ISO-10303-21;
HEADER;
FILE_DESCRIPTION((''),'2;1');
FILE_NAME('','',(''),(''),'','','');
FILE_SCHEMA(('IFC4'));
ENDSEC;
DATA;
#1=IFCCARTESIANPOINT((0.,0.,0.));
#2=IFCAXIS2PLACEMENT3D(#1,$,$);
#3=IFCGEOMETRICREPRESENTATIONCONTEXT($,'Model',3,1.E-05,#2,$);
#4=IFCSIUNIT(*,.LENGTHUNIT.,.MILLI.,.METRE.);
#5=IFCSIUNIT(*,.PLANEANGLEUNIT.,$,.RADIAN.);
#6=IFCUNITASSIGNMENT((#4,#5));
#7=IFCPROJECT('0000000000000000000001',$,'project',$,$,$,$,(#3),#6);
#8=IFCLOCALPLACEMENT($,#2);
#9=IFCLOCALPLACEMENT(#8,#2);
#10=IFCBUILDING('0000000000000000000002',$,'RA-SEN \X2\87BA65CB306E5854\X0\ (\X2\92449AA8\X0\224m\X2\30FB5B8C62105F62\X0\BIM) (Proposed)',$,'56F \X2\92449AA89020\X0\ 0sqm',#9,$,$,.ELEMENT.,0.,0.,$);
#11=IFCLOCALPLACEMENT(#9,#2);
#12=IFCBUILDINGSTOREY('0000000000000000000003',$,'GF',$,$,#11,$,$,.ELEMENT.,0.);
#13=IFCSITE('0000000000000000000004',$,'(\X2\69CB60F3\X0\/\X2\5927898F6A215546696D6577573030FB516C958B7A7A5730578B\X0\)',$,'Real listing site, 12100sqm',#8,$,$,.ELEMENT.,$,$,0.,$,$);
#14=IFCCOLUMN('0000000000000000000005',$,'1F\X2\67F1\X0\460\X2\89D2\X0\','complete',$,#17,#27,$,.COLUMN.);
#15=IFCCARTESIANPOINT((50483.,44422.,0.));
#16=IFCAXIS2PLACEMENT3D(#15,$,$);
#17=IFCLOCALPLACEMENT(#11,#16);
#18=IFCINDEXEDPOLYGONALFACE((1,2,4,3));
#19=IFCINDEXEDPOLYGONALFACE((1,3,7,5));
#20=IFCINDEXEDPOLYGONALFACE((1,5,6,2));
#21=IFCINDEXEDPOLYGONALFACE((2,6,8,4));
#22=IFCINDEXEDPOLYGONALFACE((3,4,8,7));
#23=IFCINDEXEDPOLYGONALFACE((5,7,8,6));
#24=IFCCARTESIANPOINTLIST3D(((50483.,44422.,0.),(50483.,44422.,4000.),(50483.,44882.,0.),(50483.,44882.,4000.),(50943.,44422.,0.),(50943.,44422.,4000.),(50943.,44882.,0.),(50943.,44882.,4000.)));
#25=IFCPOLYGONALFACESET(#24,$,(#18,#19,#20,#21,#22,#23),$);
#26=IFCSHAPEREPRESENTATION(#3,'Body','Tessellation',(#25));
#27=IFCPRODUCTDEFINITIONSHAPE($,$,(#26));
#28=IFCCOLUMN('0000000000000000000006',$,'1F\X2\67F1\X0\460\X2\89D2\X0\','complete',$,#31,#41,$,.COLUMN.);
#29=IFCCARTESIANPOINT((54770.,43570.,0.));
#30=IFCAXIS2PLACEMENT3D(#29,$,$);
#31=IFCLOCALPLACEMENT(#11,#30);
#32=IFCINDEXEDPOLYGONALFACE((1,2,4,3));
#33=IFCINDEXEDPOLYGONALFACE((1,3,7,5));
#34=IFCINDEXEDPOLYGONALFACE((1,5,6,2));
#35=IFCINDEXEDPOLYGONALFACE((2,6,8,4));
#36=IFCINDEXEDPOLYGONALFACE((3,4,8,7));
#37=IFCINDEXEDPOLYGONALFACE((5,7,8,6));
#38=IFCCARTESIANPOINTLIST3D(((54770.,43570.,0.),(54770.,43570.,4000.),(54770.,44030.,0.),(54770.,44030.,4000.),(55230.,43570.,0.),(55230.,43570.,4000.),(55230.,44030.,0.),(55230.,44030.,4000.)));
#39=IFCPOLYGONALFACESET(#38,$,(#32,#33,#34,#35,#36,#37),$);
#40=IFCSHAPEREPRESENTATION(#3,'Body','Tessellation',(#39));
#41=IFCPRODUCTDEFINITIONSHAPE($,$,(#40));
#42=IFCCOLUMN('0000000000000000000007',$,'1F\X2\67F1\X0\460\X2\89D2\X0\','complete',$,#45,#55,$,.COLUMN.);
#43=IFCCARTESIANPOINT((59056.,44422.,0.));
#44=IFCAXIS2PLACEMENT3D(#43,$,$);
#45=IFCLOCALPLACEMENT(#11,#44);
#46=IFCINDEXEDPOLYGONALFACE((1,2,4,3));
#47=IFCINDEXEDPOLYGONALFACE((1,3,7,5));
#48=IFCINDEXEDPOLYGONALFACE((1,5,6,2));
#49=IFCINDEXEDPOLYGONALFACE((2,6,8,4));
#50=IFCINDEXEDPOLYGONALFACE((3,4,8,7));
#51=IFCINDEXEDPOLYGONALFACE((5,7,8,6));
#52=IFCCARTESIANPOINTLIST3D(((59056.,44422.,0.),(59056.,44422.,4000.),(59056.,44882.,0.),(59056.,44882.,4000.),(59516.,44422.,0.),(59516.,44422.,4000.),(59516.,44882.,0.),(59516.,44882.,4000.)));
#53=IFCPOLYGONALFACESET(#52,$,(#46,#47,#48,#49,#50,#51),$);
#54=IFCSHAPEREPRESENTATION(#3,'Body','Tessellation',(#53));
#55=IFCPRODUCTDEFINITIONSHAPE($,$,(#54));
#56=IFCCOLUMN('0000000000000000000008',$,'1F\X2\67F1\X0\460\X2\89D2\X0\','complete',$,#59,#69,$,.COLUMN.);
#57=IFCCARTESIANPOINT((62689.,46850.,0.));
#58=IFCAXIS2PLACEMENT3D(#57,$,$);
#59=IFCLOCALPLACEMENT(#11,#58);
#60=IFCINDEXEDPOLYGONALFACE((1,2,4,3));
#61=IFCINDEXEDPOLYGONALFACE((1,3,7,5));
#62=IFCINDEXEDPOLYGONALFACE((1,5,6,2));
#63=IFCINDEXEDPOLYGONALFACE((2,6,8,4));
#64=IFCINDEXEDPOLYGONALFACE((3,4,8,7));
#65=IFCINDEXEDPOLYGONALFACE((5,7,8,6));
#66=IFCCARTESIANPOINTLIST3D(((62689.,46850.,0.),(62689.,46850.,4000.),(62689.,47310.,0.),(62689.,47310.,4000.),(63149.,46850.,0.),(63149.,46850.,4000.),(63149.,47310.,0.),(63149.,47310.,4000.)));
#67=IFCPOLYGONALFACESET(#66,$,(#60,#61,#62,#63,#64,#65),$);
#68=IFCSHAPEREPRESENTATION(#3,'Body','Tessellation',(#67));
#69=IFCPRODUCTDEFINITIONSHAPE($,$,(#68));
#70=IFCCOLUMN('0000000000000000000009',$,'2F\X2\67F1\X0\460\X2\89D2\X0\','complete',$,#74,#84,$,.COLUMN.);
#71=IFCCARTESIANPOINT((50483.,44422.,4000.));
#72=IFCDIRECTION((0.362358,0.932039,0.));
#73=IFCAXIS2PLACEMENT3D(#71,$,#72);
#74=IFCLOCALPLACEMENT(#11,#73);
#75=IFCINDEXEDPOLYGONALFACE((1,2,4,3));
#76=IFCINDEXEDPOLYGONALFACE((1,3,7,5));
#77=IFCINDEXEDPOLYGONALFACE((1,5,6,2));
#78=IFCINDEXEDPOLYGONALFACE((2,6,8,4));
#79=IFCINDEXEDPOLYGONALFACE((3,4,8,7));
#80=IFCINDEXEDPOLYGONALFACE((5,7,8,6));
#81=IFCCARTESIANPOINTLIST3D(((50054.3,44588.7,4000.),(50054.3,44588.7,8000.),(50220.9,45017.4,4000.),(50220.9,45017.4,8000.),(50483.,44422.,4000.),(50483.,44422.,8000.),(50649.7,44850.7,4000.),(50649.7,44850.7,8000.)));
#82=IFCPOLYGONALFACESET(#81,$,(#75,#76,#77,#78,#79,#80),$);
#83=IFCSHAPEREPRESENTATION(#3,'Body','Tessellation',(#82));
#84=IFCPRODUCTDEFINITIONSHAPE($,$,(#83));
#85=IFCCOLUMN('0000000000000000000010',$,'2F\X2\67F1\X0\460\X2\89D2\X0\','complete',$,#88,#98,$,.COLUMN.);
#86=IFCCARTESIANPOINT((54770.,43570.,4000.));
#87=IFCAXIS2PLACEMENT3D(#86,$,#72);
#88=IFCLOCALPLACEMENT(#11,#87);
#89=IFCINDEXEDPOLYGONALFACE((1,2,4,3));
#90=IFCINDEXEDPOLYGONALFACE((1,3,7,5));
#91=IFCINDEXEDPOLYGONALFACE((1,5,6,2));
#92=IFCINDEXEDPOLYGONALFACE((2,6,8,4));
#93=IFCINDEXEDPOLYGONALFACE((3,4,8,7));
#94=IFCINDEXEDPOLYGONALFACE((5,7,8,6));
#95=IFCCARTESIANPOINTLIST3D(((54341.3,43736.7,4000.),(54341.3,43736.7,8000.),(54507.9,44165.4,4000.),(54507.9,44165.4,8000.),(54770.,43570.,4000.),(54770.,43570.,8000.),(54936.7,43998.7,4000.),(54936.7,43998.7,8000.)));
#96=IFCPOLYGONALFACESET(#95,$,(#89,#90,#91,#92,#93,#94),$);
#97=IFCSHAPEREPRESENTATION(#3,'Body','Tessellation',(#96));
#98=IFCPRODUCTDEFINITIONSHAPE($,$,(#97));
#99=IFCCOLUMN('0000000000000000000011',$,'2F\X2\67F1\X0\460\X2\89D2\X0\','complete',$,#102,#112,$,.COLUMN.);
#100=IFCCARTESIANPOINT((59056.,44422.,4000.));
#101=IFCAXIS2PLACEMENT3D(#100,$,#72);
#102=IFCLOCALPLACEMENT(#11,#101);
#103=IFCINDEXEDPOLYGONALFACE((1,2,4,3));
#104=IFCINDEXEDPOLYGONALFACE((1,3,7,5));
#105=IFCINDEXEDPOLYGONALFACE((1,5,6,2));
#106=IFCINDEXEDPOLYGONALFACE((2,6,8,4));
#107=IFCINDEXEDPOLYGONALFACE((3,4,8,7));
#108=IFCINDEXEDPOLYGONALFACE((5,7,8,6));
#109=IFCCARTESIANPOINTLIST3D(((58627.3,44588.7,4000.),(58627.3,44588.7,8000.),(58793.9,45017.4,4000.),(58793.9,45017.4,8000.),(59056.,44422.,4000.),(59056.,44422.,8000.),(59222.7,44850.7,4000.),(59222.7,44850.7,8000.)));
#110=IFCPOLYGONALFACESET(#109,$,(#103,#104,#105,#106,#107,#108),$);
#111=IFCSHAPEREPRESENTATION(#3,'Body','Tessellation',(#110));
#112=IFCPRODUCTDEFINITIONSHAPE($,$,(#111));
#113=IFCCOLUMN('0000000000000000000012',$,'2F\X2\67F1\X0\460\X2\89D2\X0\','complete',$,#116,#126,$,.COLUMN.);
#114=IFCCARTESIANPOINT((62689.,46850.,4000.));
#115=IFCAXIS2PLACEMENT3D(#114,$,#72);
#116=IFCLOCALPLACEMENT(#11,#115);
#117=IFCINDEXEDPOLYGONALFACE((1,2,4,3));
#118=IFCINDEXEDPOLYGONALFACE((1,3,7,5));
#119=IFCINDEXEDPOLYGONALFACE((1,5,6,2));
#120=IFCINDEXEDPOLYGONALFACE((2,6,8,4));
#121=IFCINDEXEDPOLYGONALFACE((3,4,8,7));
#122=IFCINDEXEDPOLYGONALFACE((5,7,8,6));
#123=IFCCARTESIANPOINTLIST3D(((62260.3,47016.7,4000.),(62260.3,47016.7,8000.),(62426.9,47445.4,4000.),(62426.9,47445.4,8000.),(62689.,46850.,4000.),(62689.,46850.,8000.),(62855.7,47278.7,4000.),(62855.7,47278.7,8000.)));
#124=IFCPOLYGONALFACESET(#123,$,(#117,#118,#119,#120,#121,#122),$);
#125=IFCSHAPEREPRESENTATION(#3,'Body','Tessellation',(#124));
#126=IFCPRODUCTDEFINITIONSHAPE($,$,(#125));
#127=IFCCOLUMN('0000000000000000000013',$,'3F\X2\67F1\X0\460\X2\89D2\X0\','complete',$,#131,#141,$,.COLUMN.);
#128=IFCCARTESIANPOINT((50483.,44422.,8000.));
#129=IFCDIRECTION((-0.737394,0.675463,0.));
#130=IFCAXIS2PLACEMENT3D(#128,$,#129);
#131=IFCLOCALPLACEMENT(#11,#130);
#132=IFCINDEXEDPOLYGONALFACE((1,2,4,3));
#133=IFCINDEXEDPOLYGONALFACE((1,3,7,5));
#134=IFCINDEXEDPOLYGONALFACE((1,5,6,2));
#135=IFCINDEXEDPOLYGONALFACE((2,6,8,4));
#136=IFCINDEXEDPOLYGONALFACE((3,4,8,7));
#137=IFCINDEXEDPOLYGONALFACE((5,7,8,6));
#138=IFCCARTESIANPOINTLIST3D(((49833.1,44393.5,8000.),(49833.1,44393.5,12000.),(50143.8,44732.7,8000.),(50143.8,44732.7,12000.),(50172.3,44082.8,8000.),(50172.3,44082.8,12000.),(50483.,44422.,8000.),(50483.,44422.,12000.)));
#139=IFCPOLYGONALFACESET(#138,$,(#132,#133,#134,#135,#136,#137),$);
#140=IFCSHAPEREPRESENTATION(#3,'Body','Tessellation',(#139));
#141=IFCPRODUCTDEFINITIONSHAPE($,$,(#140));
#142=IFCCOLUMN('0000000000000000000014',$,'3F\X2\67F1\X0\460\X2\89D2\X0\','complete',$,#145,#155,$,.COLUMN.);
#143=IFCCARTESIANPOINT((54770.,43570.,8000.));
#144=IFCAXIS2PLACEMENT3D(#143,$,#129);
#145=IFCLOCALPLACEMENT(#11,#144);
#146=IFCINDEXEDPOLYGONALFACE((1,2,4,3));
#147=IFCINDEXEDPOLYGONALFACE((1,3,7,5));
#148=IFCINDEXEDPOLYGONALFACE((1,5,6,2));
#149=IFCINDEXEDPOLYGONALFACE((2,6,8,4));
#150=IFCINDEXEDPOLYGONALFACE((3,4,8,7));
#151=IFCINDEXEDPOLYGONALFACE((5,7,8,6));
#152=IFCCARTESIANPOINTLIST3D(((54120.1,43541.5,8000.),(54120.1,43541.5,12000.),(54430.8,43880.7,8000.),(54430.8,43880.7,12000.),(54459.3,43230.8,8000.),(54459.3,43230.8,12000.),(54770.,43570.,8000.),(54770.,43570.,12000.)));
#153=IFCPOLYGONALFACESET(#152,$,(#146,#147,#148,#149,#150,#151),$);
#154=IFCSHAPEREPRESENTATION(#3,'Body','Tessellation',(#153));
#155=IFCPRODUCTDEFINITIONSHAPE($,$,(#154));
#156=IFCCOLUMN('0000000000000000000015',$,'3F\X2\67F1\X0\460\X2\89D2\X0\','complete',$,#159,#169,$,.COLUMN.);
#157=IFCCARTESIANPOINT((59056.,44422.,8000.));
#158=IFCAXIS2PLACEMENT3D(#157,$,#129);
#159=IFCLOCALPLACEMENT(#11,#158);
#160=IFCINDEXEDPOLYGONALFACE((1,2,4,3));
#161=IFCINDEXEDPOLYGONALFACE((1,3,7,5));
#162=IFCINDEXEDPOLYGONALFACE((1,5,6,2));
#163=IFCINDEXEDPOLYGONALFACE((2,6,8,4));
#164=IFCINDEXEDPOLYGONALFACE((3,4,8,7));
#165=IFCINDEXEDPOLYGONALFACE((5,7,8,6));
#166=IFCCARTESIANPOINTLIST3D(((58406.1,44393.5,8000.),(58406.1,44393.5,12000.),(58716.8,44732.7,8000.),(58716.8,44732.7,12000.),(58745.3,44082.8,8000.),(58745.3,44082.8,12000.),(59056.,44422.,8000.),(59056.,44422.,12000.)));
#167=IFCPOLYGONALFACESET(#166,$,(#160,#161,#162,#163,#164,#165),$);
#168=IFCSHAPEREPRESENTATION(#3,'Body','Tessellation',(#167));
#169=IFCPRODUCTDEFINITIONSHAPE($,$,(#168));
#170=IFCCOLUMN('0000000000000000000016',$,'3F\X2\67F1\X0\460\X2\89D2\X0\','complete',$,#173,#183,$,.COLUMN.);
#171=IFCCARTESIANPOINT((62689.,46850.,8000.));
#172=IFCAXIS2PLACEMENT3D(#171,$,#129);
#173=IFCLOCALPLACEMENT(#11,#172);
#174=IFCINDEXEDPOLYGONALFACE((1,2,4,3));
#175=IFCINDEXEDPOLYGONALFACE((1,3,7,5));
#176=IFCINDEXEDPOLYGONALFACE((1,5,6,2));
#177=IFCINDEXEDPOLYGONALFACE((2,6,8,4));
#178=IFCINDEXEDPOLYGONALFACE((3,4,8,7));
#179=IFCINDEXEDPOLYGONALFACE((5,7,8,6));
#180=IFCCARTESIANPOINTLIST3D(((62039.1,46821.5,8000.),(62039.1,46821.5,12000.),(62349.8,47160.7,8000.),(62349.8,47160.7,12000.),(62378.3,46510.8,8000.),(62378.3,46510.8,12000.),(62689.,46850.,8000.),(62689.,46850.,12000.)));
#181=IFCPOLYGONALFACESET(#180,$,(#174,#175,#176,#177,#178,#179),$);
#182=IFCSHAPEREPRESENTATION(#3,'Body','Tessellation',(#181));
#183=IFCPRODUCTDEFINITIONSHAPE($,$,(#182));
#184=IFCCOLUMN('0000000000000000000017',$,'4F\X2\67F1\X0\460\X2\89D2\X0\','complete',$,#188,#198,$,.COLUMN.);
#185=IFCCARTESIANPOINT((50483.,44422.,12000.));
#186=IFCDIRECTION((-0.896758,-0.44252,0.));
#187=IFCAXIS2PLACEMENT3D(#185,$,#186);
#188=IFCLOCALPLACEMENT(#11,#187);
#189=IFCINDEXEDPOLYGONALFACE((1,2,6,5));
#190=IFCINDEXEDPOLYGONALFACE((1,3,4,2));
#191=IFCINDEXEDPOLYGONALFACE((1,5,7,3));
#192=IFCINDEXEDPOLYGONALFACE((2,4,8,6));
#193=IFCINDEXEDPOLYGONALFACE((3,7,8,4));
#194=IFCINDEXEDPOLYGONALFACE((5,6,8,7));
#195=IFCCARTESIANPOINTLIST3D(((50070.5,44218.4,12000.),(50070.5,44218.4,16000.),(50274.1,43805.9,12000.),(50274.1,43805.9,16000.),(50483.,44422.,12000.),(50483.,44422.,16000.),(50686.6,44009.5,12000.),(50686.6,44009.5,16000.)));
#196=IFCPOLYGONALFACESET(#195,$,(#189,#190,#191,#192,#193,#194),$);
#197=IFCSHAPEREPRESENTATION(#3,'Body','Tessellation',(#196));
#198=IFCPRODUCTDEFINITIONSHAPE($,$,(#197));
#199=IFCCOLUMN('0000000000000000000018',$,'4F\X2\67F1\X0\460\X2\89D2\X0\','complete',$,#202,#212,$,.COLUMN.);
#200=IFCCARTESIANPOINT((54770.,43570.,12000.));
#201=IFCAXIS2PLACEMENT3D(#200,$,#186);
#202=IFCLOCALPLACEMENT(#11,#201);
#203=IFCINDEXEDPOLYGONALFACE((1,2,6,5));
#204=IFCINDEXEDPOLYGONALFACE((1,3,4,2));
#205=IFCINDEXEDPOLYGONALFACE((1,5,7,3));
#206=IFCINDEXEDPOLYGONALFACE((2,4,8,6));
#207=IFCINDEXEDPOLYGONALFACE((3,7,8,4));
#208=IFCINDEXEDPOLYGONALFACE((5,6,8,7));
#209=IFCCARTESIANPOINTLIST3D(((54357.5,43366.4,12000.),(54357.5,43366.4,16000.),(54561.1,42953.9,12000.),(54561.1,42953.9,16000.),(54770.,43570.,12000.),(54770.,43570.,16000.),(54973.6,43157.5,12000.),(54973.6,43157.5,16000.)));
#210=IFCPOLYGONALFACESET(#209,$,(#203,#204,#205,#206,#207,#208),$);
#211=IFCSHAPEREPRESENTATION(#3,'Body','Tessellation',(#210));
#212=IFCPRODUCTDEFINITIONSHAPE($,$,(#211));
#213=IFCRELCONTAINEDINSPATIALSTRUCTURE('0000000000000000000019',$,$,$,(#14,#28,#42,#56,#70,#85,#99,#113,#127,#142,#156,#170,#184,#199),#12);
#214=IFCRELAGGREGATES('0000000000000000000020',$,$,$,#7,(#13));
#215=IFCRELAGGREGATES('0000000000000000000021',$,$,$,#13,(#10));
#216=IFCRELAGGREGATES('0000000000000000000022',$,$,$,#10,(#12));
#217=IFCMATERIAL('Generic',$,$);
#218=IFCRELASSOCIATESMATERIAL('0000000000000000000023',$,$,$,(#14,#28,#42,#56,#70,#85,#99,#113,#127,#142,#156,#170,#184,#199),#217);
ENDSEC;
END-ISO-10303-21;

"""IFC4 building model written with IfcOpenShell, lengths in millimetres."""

from ifc_helpers import new_model, si_unit, frame, frame_2d, origin, place, context, project, spatial, rectangle, extrude, material, element, save


model = new_model("IFC4")

# Units and contexts
model_context = context("Model", 3, precision=1e-05, world=origin())
ifc_project = project(units=[si_unit("LENGTHUNIT", "METRE", prefix="MILLI"), si_unit("PLANEANGLEUNIT", "RADIAN")], contexts=[model_context])

# Site, building, storey
site_placement = place(None, origin())
site = spatial("IfcSite", under=ifc_project, at=site_placement, Name="(構想/大規模商業敷地・公開空地型)", ObjectType="Real listing site, 12100sqm", CompositionType="ELEMENT", RefElevation=0.0)
building_placement = place(site_placement, origin())
building = spatial("IfcBuilding", under=site, at=building_placement, Name="RA-SEN 螺旋の塔 (鉄骨224m・完成形BIM) (Proposed)", ObjectType="56F 鉄骨造 0sqm", CompositionType="ELEMENT", ElevationOfRefHeight=0.0, ElevationOfTerrain=0.0)
storey_placement = place(building_placement, origin())
storey = spatial("IfcBuildingStorey", under=building, at=storey_placement, Name="GF", CompositionType="ELEMENT", Elevation=0.0)

# Columns
ifc_material = material(Name="Generic")
column_1_placement = place(storey_placement, frame((50483.0, 44422.0, 0.0)))
element("IfcColumn", 1, at=column_1_placement, inside=storey, material=ifc_material, Name="1F柱460角", Description="complete", PredefinedType="COLUMN", context=model_context, shape_type="SweptSolid", body=[
    extrude(rectangle(XDim=460.0, YDim=460.0, at=frame_2d((230.0, 230.0))), frame((50483.0, 44422.0, 0.0)), (0.0, 0.0, 1.0), 4000.0),
])
column_2_placement = place(storey_placement, frame((54770.0, 43570.0, 0.0)))
element("IfcColumn", 2, at=column_2_placement, inside=storey, material=ifc_material, Name="1F柱460角", Description="complete", PredefinedType="COLUMN", context=model_context, shape_type="SweptSolid", body=[
    extrude(rectangle(XDim=460.0, YDim=460.0, at=frame_2d((230.0, 230.0))), frame((54770.0, 43570.0, 0.0)), (0.0, 0.0, 1.0), 4000.0),
])
column_3_placement = place(storey_placement, frame((59056.0, 44422.0, 0.0)))
element("IfcColumn", 3, at=column_3_placement, inside=storey, material=ifc_material, Name="1F柱460角", Description="complete", PredefinedType="COLUMN", context=model_context, shape_type="SweptSolid", body=[
    extrude(rectangle(XDim=460.0, YDim=460.0, at=frame_2d((230.0, 230.0))), frame((59056.0, 44422.0, 0.0)), (0.0, 0.0, 1.0), 4000.0),
])
column_4_placement = place(storey_placement, frame((62689.0, 46850.0, 0.0)))
element("IfcColumn", 4, at=column_4_placement, inside=storey, material=ifc_material, Name="1F柱460角", Description="complete", PredefinedType="COLUMN", context=model_context, shape_type="SweptSolid", body=[
    extrude(rectangle(XDim=460.0, YDim=460.0, at=frame_2d((230.0, 230.0))), frame((62689.0, 46850.0, 0.0)), (0.0, 0.0, 1.0), 4000.0),
])
column_5_placement = place(storey_placement, frame((50483.0, 44422.0, 4000.0), x_axis=(0.362358, 0.932039, 0.0)))
element("IfcColumn", 5, at=column_5_placement, inside=storey, material=ifc_material, Name="2F柱460角", Description="complete", PredefinedType="COLUMN", context=model_context, shape_type="SweptSolid", body=[
    extrude(rectangle(XDim=460.0, YDim=460.0, at=frame_2d((230.0, 230.0))), frame((50483.0, 44422.0, 4000.0), x_axis=(0.362358, 0.932039, 0.0)), (0.0, 0.0, 1.0), 4000.0),
])
column_6_placement = place(storey_placement, frame((54770.0, 43570.0, 4000.0), x_axis=(0.362358, 0.932039, 0.0)))
element("IfcColumn", 6, at=column_6_placement, inside=storey, material=ifc_material, Name="2F柱460角", Description="complete", PredefinedType="COLUMN", context=model_context, shape_type="SweptSolid", body=[
    extrude(rectangle(XDim=460.0, YDim=460.0, at=frame_2d((230.0, 230.0))), frame((54770.0, 43570.0, 4000.0), x_axis=(0.362358, 0.932039, 0.0)), (0.0, 0.0, 1.0), 4000.0),
])
column_7_placement = place(storey_placement, frame((59056.0, 44422.0, 4000.0), x_axis=(0.362358, 0.932039, 0.0)))
element("IfcColumn", 7, at=column_7_placement, inside=storey, material=ifc_material, Name="2F柱460角", Description="complete", PredefinedType="COLUMN", context=model_context, shape_type="SweptSolid", body=[
    extrude(rectangle(XDim=460.0, YDim=460.0, at=frame_2d((230.0, 230.0))), frame((59056.0, 44422.0, 4000.0), x_axis=(0.362358, 0.932039, 0.0)), (0.0, 0.0, 1.0), 4000.0),
])
column_8_placement = place(storey_placement, frame((62689.0, 46850.0, 4000.0), x_axis=(0.362358, 0.932039, 0.0)))
element("IfcColumn", 8, at=column_8_placement, inside=storey, material=ifc_material, Name="2F柱460角", Description="complete", PredefinedType="COLUMN", context=model_context, shape_type="SweptSolid", body=[
    extrude(rectangle(XDim=460.0, YDim=460.0, at=frame_2d((230.0, 230.0))), frame((62689.0, 46850.0, 4000.0), x_axis=(0.362358, 0.932039, 0.0)), (0.0, 0.0, 1.0), 4000.0),
])
column_9_placement = place(storey_placement, frame((50483.0, 44422.0, 8000.0), x_axis=(-0.737394, 0.675463, 0.0)))
element("IfcColumn", 9, at=column_9_placement, inside=storey, material=ifc_material, Name="3F柱460角", Description="complete", PredefinedType="COLUMN", context=model_context, shape_type="SweptSolid", body=[
    extrude(rectangle(XDim=460.0, YDim=460.0, at=frame_2d((230.0, 230.0))), frame((50483.0, 44422.0, 8000.0), x_axis=(-0.737394, 0.675463, 0.0)), (0.0, 0.0, 1.0), 4000.0),
])
column_10_placement = place(storey_placement, frame((54770.0, 43570.0, 8000.0), x_axis=(-0.737394, 0.675463, 0.0)))
element("IfcColumn", 10, at=column_10_placement, inside=storey, material=ifc_material, Name="3F柱460角", Description="complete", PredefinedType="COLUMN", context=model_context, shape_type="SweptSolid", body=[
    extrude(rectangle(XDim=460.0, YDim=460.0, at=frame_2d((230.0, 230.0))), frame((54770.0, 43570.0, 8000.0), x_axis=(-0.737394, 0.675463, 0.0)), (0.0, 0.0, 1.0), 4000.0),
])
column_11_placement = place(storey_placement, frame((59056.0, 44422.0, 8000.0), x_axis=(-0.737394, 0.675463, 0.0)))
element("IfcColumn", 11, at=column_11_placement, inside=storey, material=ifc_material, Name="3F柱460角", Description="complete", PredefinedType="COLUMN", context=model_context, shape_type="SweptSolid", body=[
    extrude(rectangle(XDim=460.0, YDim=460.0, at=frame_2d((230.0, 230.0))), frame((59056.0, 44422.0, 8000.0), x_axis=(-0.737394, 0.675463, 0.0)), (0.0, 0.0, 1.0), 4000.0),
])
column_12_placement = place(storey_placement, frame((62689.0, 46850.0, 8000.0), x_axis=(-0.737394, 0.675463, 0.0)))
element("IfcColumn", 12, at=column_12_placement, inside=storey, material=ifc_material, Name="3F柱460角", Description="complete", PredefinedType="COLUMN", context=model_context, shape_type="SweptSolid", body=[
    extrude(rectangle(XDim=460.0, YDim=460.0, at=frame_2d((230.0, 230.0))), frame((62689.0, 46850.0, 8000.0), x_axis=(-0.737394, 0.675463, 0.0)), (0.0, 0.0, 1.0), 4000.0),
])
column_13_placement = place(storey_placement, frame((50483.0, 44422.0, 12000.0), x_axis=(-0.896758, -0.44252, 0.0)))
element("IfcColumn", 13, at=column_13_placement, inside=storey, material=ifc_material, Name="4F柱460角", Description="complete", PredefinedType="COLUMN", context=model_context, shape_type="SweptSolid", body=[
    extrude(rectangle(XDim=460.0, YDim=460.0, at=frame_2d((230.0, 230.0))), frame((50483.0, 44422.0, 12000.0), x_axis=(-0.896758, -0.44252, 0.0)), (0.0, 0.0, 1.0), 4000.0),
])
column_14_placement = place(storey_placement, frame((54770.0, 43570.0, 12000.0), x_axis=(-0.896758, -0.44252, 0.0)))
element("IfcColumn", 14, at=column_14_placement, inside=storey, material=ifc_material, Name="4F柱460角", Description="complete", PredefinedType="COLUMN", context=model_context, shape_type="SweptSolid", body=[
    extrude(rectangle(XDim=460.0, YDim=460.0, at=frame_2d((230.0, 230.0))), frame((54770.0, 43570.0, 12000.0), x_axis=(-0.896758, -0.44252, 0.0)), (0.0, 0.0, 1.0), 4000.0),
])

save(model, "model.ifc")
